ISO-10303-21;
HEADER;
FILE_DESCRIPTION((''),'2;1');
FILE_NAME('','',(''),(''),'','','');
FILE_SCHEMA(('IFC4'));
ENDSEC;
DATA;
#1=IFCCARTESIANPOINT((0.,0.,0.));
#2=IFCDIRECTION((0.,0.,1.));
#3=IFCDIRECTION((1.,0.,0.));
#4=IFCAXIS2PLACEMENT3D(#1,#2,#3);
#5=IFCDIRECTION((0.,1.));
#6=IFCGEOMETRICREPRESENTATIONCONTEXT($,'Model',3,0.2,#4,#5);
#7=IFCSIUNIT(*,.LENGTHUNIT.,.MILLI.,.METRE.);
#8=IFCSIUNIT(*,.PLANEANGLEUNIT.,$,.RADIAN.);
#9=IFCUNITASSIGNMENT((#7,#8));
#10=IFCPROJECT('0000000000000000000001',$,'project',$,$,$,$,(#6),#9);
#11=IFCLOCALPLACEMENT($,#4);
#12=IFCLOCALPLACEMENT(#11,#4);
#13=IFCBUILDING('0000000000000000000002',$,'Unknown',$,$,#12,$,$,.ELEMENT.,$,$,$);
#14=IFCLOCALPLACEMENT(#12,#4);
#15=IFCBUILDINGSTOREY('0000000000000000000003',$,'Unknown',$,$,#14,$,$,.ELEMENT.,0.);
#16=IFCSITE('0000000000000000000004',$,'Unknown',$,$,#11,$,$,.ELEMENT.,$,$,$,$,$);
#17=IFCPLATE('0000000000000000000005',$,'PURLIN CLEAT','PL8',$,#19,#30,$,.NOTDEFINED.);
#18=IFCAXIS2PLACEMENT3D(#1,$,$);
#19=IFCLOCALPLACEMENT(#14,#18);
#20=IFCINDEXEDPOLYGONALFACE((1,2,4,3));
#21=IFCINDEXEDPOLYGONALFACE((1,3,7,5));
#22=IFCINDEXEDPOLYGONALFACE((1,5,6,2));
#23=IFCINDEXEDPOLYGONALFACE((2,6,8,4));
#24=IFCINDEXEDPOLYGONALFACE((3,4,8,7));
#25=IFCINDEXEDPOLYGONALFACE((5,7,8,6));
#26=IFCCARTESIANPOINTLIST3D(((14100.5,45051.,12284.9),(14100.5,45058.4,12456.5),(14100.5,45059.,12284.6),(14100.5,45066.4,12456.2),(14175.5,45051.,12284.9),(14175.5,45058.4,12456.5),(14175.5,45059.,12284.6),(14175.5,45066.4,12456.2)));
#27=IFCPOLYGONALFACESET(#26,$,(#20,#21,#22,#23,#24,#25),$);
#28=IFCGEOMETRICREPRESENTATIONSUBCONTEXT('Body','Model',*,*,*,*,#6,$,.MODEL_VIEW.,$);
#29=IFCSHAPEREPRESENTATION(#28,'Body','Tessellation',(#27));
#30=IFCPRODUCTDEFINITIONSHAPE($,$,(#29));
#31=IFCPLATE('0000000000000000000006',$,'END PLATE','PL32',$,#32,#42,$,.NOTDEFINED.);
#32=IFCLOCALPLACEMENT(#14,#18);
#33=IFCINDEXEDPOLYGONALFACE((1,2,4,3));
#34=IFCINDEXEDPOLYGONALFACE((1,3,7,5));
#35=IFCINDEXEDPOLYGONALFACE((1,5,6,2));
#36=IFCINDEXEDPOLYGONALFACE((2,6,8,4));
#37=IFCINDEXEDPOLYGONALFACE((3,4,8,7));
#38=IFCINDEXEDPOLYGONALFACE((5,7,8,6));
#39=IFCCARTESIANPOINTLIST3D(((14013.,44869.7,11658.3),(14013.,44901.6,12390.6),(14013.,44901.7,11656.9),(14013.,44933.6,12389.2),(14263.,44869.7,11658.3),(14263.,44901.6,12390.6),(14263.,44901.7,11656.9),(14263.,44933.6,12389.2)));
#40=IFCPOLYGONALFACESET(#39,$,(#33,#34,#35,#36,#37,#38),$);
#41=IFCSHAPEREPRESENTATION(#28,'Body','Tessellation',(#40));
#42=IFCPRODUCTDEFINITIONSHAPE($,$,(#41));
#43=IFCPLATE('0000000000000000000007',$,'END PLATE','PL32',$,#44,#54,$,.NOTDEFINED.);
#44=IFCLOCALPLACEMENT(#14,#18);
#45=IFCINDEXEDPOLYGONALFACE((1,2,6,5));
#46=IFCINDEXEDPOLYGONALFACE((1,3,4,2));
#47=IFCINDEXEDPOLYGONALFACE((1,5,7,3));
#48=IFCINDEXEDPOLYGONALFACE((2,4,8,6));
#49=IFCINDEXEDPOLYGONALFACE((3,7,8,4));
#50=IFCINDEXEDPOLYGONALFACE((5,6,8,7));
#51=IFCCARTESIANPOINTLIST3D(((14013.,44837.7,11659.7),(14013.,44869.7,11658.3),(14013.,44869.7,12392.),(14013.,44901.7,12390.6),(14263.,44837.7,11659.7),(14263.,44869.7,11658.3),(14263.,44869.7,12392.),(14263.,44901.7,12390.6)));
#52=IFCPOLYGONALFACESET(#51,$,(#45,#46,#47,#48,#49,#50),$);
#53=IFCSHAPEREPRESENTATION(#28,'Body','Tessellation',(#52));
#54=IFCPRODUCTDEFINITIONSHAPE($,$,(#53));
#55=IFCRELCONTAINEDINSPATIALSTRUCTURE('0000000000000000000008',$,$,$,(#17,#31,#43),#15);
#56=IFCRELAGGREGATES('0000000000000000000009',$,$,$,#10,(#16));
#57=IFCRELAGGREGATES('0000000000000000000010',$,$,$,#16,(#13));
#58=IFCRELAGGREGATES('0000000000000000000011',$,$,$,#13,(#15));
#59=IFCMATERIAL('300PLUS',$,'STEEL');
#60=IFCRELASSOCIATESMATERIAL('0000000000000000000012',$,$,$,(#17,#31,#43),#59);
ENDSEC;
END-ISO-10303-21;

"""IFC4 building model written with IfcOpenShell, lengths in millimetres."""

from ifc_helpers import new_model, si_unit, direction, frame, origin_with_axes, place, context, subcontext, project, spatial, line, indexed_curve, outline, extrude, material, element, save


model = new_model("IFC4")

# Units and contexts
model_context = context("Model", 3, precision=0.2, world=origin_with_axes(), true_north=direction((0.0, 1.0)))
body_context = subcontext(model_context, "Body", "Model", "MODEL_VIEW")
ifc_project = project(units=[si_unit("LENGTHUNIT", "METRE", prefix="MILLI"), si_unit("PLANEANGLEUNIT", "RADIAN")], contexts=[model_context])

# Site, building, storey
site_placement = place(None, origin_with_axes())
site = spatial("IfcSite", under=ifc_project, at=site_placement, Name="Unknown", CompositionType="ELEMENT")
building_placement = place(site_placement, origin_with_axes())
building = spatial("IfcBuilding", under=site, at=building_placement, Name="Unknown", CompositionType="ELEMENT")
storey_placement = place(building_placement, origin_with_axes())
storey = spatial("IfcBuildingStorey", under=building, at=storey_placement, Name="Unknown", CompositionType="ELEMENT", Elevation=0.0)

# Plates
ifc_material_1 = material(Name="300PLUS", Category="STEEL")
for number, where, z_axis, x_axis, name in (
    (1, (14100.5, 45055.0, 12284.8), (0.0, -0.999071, 0.043084), (1.0, 0.0, 0.0), "PURLIN CLEAT"),
):
    element("IfcPlate", number, at=place(storey_placement, frame(where, z_axis=z_axis, x_axis=x_axis)), inside=storey, material=ifc_material_1, Name=name, Description="PL8", PredefinedType="NOTDEFINED", context=body_context, shape_type="SolidModel", body=[
        extrude(outline(indexed_curve([(0.0, 0.0), (75.0, 0.0), (75.0, 171.8), (0.0, 171.8)], segments=[line(1, 2, 3, 4, 1)])), frame((0.0, 0.0, 4.0), z_axis=(0.0, 0.0, 1.0), x_axis=(1.0, 0.0, 0.0)), (0.0, 0.0, -1.0), 8.0),
    ])
plate_1_placement = place(storey_placement, frame((14263.0, 44917.6, 12389.9), z_axis=(0.0, -0.999053, 0.04352), x_axis=(-1.0, 0.0, 0.0)))
element("IfcPlate", 2, at=plate_1_placement, inside=storey, material=ifc_material_1, Name="END PLATE", Description="PL32", PredefinedType="NOTDEFINED", context=body_context, shape_type="SolidModel", body=[
    extrude(outline(indexed_curve([(0.0, 0.0), (250.0, 0.0), (250.0, 733.0), (0.0, 733.0)], segments=[line(1, 2, 3, 4, 1)])), frame((0.0, 0.0, 16.0), z_axis=(0.0, 0.0, 1.0), x_axis=(1.0, 0.0, 0.0)), (0.0, 0.0, -1.0), 32.0),
])
plate_2_placement = place(storey_placement, frame((14263.0, 44885.7, 12391.3), z_axis=(0.0, -0.999047, 0.043656), x_axis=(-1.0, 0.0, 0.0)))
element("IfcPlate", 3, at=plate_2_placement, inside=storey, material=ifc_material_1, Name="END PLATE", Description="PL32", PredefinedType="NOTDEFINED", context=body_context, shape_type="SolidModel", body=[
    extrude(outline(indexed_curve([(0.0, 0.0), (250.0, 0.0), (250.0, 733.0), (0.0, 733.0)], segments=[line(1, 2, 3, 4, 1)])), frame((0.0, 0.0, 16.0), z_axis=(0.0, 0.0, 1.0), x_axis=(1.0, 0.0, 0.0)), (0.0, 0.0, -1.0), 32.0),
])

save(model, "model.ifc")
